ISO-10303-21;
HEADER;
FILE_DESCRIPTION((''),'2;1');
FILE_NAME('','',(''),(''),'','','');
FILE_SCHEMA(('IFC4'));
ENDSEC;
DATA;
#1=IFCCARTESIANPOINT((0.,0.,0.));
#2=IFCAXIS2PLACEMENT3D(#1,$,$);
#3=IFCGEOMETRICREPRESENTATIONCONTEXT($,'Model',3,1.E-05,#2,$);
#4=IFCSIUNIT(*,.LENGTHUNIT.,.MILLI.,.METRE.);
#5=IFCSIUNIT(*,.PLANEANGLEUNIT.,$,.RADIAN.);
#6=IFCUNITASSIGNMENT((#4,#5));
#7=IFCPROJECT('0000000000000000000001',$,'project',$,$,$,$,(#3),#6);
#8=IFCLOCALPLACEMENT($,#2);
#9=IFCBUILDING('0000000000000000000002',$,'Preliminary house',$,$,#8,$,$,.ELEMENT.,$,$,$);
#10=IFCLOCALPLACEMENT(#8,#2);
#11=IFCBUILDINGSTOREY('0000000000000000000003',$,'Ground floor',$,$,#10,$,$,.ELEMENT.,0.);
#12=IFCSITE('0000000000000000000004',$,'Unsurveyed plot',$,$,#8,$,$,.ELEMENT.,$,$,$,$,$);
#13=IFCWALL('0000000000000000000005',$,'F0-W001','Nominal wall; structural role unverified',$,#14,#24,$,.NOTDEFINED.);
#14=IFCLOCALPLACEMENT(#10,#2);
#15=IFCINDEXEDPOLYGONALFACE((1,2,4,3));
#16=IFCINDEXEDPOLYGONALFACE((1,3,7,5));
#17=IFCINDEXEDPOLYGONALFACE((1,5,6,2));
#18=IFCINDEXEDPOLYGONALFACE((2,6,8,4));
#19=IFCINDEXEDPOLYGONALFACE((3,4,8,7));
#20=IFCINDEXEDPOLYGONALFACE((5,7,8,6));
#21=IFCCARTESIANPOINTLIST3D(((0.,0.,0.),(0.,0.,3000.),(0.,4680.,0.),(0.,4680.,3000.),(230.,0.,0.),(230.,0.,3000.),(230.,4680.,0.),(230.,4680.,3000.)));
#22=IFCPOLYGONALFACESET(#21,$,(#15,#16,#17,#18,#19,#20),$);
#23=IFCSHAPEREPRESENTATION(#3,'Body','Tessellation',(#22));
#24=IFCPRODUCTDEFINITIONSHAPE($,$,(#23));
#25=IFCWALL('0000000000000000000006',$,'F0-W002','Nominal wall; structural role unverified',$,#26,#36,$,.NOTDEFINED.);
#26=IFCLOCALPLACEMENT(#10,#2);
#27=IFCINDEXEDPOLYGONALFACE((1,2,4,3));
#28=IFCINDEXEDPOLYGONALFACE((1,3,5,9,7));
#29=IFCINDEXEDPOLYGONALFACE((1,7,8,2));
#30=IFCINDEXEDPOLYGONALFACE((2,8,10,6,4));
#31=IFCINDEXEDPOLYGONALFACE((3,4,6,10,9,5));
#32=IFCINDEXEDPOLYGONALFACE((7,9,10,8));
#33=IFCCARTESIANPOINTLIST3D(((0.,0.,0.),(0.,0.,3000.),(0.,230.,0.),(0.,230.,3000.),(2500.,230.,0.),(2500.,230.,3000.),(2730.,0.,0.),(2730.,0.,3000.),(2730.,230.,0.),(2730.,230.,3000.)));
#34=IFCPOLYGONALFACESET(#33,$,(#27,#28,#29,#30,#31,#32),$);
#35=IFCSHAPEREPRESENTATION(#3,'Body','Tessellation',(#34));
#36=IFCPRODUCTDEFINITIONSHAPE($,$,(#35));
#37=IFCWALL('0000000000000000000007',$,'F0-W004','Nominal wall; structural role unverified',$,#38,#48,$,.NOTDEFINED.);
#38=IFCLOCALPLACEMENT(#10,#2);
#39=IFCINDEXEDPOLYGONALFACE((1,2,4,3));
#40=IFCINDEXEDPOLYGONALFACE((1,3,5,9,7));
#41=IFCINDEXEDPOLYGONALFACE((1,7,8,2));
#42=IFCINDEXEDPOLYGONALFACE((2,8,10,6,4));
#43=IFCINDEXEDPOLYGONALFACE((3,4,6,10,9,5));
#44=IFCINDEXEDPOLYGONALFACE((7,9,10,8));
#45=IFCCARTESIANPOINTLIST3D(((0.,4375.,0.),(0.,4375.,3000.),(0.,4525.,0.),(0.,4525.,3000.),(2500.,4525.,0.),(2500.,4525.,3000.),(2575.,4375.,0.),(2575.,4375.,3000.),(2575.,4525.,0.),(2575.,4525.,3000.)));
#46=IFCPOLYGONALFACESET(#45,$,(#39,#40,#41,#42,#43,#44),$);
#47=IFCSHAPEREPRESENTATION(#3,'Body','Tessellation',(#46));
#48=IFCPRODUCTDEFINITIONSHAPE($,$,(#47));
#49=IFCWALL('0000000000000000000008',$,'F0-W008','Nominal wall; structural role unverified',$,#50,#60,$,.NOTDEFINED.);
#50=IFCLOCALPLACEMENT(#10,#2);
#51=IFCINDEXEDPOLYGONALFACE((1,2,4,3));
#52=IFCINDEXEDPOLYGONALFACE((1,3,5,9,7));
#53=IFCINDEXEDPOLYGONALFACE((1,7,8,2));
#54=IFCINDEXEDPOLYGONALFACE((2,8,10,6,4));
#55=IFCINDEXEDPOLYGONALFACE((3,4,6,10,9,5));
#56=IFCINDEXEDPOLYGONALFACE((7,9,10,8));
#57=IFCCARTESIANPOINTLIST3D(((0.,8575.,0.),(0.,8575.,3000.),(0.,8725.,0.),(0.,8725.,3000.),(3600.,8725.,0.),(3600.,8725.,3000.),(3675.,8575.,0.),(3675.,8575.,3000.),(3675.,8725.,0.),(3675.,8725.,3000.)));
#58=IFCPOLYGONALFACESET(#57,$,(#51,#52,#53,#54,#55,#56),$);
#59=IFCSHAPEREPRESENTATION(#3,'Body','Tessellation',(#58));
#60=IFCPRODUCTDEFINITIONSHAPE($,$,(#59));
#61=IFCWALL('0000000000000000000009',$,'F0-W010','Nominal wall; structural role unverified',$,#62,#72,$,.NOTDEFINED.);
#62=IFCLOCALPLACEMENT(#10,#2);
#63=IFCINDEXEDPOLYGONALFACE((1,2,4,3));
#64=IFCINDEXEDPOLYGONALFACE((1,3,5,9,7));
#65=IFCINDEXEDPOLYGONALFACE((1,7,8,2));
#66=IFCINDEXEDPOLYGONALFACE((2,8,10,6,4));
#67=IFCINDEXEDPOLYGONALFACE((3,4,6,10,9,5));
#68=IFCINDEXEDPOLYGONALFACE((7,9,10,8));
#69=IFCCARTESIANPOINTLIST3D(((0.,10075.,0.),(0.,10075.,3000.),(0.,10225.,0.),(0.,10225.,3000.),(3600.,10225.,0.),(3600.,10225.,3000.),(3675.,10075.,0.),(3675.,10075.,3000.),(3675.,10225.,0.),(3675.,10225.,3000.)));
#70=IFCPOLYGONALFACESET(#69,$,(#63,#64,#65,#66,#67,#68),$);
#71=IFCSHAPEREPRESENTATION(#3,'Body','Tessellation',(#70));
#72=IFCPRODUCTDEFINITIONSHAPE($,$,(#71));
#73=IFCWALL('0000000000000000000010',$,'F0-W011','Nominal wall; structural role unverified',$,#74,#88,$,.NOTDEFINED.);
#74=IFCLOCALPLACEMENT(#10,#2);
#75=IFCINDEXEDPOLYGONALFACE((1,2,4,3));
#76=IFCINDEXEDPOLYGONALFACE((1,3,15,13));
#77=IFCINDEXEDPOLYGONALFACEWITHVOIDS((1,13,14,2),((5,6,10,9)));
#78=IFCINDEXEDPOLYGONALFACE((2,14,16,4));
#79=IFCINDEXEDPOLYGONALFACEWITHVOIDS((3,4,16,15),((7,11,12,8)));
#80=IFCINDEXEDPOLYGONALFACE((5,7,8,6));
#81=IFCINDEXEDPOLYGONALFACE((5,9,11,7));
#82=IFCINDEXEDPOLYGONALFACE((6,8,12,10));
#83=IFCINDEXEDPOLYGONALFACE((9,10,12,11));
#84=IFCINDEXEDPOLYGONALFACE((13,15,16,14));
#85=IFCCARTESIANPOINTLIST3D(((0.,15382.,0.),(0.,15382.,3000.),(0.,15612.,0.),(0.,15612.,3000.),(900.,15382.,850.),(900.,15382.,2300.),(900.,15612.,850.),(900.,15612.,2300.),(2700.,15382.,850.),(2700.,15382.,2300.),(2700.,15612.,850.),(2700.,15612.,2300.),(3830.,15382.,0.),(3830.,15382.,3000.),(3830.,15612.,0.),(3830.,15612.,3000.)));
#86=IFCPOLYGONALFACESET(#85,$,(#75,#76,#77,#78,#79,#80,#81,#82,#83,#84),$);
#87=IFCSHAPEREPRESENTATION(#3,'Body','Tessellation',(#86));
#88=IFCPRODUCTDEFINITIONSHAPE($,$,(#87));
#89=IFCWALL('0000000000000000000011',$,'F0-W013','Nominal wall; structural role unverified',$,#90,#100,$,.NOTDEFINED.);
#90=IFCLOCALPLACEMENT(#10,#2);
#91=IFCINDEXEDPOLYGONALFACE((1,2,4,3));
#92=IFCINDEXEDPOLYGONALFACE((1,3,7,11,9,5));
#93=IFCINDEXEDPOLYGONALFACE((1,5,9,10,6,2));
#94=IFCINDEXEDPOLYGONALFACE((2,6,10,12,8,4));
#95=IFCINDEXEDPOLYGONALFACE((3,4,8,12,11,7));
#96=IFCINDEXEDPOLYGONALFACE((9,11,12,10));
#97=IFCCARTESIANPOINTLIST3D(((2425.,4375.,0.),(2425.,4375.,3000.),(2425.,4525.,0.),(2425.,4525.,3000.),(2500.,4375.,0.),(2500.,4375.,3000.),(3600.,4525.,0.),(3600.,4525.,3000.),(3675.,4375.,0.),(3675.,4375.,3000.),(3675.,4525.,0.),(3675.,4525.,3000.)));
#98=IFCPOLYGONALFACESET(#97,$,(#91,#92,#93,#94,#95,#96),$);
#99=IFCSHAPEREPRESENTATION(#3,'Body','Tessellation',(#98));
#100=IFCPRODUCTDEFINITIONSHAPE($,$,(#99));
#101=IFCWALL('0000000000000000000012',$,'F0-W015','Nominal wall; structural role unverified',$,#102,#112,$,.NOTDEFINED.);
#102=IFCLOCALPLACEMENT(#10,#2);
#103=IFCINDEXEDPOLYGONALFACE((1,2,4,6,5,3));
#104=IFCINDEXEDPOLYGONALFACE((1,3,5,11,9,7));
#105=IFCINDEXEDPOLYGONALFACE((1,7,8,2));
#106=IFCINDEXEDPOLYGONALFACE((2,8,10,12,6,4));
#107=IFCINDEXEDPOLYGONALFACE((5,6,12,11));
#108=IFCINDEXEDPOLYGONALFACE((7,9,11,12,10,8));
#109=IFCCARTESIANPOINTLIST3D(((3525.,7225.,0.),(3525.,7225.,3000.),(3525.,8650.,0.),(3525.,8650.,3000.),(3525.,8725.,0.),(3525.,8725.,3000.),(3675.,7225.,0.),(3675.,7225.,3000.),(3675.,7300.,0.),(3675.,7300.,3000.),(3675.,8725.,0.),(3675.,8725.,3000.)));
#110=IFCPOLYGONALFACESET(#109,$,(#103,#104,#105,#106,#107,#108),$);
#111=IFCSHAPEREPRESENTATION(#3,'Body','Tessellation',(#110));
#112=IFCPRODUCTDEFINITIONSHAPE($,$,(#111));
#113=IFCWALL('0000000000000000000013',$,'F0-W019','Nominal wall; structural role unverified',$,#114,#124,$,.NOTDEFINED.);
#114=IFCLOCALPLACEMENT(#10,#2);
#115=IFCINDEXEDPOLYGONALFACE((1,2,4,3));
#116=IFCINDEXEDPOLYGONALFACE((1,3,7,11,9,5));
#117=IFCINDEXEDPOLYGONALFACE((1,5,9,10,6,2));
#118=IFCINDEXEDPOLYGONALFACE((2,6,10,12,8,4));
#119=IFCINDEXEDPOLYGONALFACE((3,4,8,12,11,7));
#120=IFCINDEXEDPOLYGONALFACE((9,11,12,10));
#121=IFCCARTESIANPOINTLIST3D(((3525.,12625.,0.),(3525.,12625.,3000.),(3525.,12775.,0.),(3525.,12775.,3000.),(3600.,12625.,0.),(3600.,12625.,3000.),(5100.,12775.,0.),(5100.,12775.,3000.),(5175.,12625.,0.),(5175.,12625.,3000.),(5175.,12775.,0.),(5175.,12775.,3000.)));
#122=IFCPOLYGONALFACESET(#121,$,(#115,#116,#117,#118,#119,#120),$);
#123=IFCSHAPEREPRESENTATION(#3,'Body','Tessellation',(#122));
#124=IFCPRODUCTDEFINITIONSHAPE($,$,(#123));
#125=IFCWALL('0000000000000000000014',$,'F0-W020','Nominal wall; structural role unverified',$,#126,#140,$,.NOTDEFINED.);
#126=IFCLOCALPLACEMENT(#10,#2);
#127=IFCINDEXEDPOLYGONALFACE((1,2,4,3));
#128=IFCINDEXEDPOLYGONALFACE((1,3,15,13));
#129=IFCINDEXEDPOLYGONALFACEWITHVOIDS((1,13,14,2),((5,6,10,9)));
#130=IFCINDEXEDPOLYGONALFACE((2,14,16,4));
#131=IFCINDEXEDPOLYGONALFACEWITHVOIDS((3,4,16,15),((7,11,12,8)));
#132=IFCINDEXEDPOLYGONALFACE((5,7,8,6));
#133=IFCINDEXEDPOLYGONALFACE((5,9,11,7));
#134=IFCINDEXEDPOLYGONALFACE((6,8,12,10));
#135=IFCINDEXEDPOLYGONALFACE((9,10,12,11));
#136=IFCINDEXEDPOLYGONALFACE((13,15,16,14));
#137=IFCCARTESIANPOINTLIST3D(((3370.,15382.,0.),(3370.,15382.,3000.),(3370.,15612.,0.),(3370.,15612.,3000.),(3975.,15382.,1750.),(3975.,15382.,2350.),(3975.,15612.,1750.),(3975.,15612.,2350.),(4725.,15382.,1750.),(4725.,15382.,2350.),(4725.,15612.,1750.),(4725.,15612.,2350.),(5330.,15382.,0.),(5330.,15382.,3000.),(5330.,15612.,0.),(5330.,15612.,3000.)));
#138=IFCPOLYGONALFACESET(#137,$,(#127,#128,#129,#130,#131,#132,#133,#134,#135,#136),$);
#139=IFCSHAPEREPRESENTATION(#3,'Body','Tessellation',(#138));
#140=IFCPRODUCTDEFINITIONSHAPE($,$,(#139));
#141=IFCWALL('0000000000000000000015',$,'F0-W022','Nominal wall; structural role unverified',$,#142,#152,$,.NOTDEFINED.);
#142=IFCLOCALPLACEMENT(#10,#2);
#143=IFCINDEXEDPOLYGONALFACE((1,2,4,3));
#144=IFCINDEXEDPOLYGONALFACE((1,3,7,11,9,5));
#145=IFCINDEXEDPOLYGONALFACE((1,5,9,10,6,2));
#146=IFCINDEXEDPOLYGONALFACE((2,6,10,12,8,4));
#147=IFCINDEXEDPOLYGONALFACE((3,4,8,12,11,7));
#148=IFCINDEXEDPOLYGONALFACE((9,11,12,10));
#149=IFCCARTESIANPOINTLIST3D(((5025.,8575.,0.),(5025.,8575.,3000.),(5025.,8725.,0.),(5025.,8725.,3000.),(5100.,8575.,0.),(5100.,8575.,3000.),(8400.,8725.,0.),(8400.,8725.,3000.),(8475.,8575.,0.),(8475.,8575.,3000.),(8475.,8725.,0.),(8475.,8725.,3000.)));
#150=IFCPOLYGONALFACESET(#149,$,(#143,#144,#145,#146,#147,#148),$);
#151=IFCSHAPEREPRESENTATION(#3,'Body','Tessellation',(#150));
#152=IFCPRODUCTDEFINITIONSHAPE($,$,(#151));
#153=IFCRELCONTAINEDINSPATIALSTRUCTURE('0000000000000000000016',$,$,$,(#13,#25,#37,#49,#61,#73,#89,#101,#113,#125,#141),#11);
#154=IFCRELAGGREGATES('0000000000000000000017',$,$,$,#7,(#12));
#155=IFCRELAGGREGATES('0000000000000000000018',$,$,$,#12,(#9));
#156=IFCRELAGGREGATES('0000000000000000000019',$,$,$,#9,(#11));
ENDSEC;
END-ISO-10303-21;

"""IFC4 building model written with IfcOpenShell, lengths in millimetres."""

from ifc_helpers import new_model, si_unit, frame, origin, place, context, project, spatial, polyline, outline, extrude, element, save


model = new_model("IFC4")

# Units and contexts
model_context = context("Model", 3, precision=1e-05, world=origin())
ifc_project = project(units=[si_unit("LENGTHUNIT", "METRE", prefix="MILLI"), si_unit("PLANEANGLEUNIT", "RADIAN")], contexts=[model_context])

# Site, building, storey
placement_1 = place(None, origin())
site = spatial("IfcSite", under=ifc_project, at=placement_1, Name="Unsurveyed plot", CompositionType="ELEMENT")
building = spatial("IfcBuilding", under=site, at=placement_1, Name="Preliminary house", CompositionType="ELEMENT")
placement_2 = place(placement_1, origin())
storey = spatial("IfcBuildingStorey", under=building, at=placement_2, Name="Ground floor", CompositionType="ELEMENT", Elevation=0.0)

# Walls
element("IfcWall", 1, at=placement_2, inside=storey, Name="F0-W001", Description="Nominal wall; structural role unverified", PredefinedType="NOTDEFINED", context=model_context, shape_type="SweptSolid", body=[
    extrude(outline(polyline([(230.0, 4680.0), (230.0, 0.0), (0.0, 0.0), (0.0, 4680.0), (230.0, 4680.0)])), origin(), (0.0, 0.0, 1.0), 3000.0),
])
element("IfcWall", 2, at=placement_2, inside=storey, Name="F0-W002", Description="Nominal wall; structural role unverified", PredefinedType="NOTDEFINED", context=model_context, shape_type="SweptSolid", body=[
    extrude(outline(polyline([(2730.0, 230.0), (2730.0, 0.0), (0.0, 0.0), (0.0, 230.0), (2500.0, 230.0), (2730.0, 230.0)])), origin(), (0.0, 0.0, 1.0), 3000.0),
])

# Wall
element("IfcWall", 3, at=placement_2, inside=storey, Name="F0-W004", Description="Nominal wall; structural role unverified", PredefinedType="NOTDEFINED", context=model_context, shape_type="SweptSolid", body=[
    extrude(outline(polyline([(2575.0, 4525.0), (2575.0, 4375.0), (0.0, 4375.0), (0.0, 4525.0), (2500.0, 4525.0), (2575.0, 4525.0)])), origin(), (0.0, 0.0, 1.0), 3000.0),
])

# Wall
element("IfcWall", 4, at=placement_2, inside=storey, Name="F0-W008", Description="Nominal wall; structural role unverified", PredefinedType="NOTDEFINED", context=model_context, shape_type="SweptSolid", body=[
    extrude(outline(polyline([(3675.0, 8725.0), (3675.0, 8575.0), (0.0, 8575.0), (0.0, 8725.0), (3600.0, 8725.0), (3675.0, 8725.0)])), origin(), (0.0, 0.0, 1.0), 3000.0),
])

# Wall
element("IfcWall", 5, at=placement_2, inside=storey, Name="F0-W010", Description="Nominal wall; structural role unverified", PredefinedType="NOTDEFINED", context=model_context, shape_type="SweptSolid", body=[
    extrude(outline(polyline([(3675.0, 10225.0), (3675.0, 10075.0), (0.0, 10075.0), (0.0, 10225.0), (3600.0, 10225.0), (3675.0, 10225.0)])), origin(), (0.0, 0.0, 1.0), 3000.0),
])

# Wall, opening
wall_1 = element("IfcWall", 6, at=placement_2, inside=storey, Name="F0-W011", Description="Nominal wall; structural role unverified", PredefinedType="NOTDEFINED", context=model_context, shape_type="SweptSolid", body=[
    extrude(outline(polyline([(3830.0, 15382.0), (0.0, 15382.0), (0.0, 15612.0), (3830.0, 15612.0), (3830.0, 15382.0)])), origin(), (0.0, 0.0, 1.0), 3000.0),
])
element("IfcOpeningElement", 7, at=placement_2, cuts=wall_1, PredefinedType="OPENING", context=model_context, shape_type="SweptSolid", body=[
    extrude(outline(polyline([(900.0, 14967.0), (2700.0, 14967.0), (2700.0, 16027.0), (900.0, 16027.0), (900.0, 14967.0)])), frame((0.0, 0.0, 850.0)), (0.0, 0.0, 1.0), 1450.0),
])

# Wall
element("IfcWall", 8, at=placement_2, inside=storey, Name="F0-W013", Description="Nominal wall; structural role unverified", PredefinedType="NOTDEFINED", context=model_context, shape_type="SweptSolid", body=[
    extrude(outline(polyline([(3675.0, 4525.0), (3675.0, 4375.0), (2500.0, 4375.0), (2425.0, 4375.0), (2425.0, 4525.0), (3600.0, 4525.0), (3675.0, 4525.0)])), origin(), (0.0, 0.0, 1.0), 3000.0),
])

# Wall
element("IfcWall", 9, at=placement_2, inside=storey, Name="F0-W015", Description="Nominal wall; structural role unverified", PredefinedType="NOTDEFINED", context=model_context, shape_type="SweptSolid", body=[
    extrude(outline(polyline([(3525.0, 8725.0), (3675.0, 8725.0), (3675.0, 7300.0), (3675.0, 7225.0), (3525.0, 7225.0), (3525.0, 8650.0), (3525.0, 8725.0)])), origin(), (0.0, 0.0, 1.0), 3000.0),
])

# Wall
element("IfcWall", 10, at=placement_2, inside=storey, Name="F0-W019", Description="Nominal wall; structural role unverified", PredefinedType="NOTDEFINED", context=model_context, shape_type="SweptSolid", body=[
    extrude(outline(polyline([(5175.0, 12775.0), (5175.0, 12625.0), (3600.0, 12625.0), (3525.0, 12625.0), (3525.0, 12775.0), (5100.0, 12775.0), (5175.0, 12775.0)])), origin(), (0.0, 0.0, 1.0), 3000.0),
])

# Wall, opening
wall_2 = element("IfcWall", 11, at=placement_2, inside=storey, Name="F0-W020", Description="Nominal wall; structural role unverified", PredefinedType="NOTDEFINED", context=model_context, shape_type="SweptSolid", body=[
    extrude(outline(polyline([(5330.0, 15382.0), (3600.0, 15382.0), (3370.0, 15382.0), (3370.0, 15612.0), (5330.0, 15612.0), (5330.0, 15382.0)])), origin(), (0.0, 0.0, 1.0), 3000.0),
])
element("IfcOpeningElement", 12, at=placement_2, cuts=wall_2, PredefinedType="OPENING", context=model_context, shape_type="SweptSolid", body=[
    extrude(outline(polyline([(3975.0, 14967.0), (4725.0, 14967.0), (4725.0, 16027.0), (3975.0, 16027.0), (3975.0, 14967.0)])), frame((0.0, 0.0, 1750.0)), (0.0, 0.0, 1.0), 600.0),
])

# Wall
element("IfcWall", 13, at=placement_2, inside=storey, Name="F0-W022", Description="Nominal wall; structural role unverified", PredefinedType="NOTDEFINED", context=model_context, shape_type="SweptSolid", body=[
    extrude(outline(polyline([(8475.0, 8725.0), (8475.0, 8575.0), (5100.0, 8575.0), (5025.0, 8575.0), (5025.0, 8725.0), (8400.0, 8725.0), (8475.0, 8725.0)])), origin(), (0.0, 0.0, 1.0), 3000.0),
])

save(model, "model.ifc")
